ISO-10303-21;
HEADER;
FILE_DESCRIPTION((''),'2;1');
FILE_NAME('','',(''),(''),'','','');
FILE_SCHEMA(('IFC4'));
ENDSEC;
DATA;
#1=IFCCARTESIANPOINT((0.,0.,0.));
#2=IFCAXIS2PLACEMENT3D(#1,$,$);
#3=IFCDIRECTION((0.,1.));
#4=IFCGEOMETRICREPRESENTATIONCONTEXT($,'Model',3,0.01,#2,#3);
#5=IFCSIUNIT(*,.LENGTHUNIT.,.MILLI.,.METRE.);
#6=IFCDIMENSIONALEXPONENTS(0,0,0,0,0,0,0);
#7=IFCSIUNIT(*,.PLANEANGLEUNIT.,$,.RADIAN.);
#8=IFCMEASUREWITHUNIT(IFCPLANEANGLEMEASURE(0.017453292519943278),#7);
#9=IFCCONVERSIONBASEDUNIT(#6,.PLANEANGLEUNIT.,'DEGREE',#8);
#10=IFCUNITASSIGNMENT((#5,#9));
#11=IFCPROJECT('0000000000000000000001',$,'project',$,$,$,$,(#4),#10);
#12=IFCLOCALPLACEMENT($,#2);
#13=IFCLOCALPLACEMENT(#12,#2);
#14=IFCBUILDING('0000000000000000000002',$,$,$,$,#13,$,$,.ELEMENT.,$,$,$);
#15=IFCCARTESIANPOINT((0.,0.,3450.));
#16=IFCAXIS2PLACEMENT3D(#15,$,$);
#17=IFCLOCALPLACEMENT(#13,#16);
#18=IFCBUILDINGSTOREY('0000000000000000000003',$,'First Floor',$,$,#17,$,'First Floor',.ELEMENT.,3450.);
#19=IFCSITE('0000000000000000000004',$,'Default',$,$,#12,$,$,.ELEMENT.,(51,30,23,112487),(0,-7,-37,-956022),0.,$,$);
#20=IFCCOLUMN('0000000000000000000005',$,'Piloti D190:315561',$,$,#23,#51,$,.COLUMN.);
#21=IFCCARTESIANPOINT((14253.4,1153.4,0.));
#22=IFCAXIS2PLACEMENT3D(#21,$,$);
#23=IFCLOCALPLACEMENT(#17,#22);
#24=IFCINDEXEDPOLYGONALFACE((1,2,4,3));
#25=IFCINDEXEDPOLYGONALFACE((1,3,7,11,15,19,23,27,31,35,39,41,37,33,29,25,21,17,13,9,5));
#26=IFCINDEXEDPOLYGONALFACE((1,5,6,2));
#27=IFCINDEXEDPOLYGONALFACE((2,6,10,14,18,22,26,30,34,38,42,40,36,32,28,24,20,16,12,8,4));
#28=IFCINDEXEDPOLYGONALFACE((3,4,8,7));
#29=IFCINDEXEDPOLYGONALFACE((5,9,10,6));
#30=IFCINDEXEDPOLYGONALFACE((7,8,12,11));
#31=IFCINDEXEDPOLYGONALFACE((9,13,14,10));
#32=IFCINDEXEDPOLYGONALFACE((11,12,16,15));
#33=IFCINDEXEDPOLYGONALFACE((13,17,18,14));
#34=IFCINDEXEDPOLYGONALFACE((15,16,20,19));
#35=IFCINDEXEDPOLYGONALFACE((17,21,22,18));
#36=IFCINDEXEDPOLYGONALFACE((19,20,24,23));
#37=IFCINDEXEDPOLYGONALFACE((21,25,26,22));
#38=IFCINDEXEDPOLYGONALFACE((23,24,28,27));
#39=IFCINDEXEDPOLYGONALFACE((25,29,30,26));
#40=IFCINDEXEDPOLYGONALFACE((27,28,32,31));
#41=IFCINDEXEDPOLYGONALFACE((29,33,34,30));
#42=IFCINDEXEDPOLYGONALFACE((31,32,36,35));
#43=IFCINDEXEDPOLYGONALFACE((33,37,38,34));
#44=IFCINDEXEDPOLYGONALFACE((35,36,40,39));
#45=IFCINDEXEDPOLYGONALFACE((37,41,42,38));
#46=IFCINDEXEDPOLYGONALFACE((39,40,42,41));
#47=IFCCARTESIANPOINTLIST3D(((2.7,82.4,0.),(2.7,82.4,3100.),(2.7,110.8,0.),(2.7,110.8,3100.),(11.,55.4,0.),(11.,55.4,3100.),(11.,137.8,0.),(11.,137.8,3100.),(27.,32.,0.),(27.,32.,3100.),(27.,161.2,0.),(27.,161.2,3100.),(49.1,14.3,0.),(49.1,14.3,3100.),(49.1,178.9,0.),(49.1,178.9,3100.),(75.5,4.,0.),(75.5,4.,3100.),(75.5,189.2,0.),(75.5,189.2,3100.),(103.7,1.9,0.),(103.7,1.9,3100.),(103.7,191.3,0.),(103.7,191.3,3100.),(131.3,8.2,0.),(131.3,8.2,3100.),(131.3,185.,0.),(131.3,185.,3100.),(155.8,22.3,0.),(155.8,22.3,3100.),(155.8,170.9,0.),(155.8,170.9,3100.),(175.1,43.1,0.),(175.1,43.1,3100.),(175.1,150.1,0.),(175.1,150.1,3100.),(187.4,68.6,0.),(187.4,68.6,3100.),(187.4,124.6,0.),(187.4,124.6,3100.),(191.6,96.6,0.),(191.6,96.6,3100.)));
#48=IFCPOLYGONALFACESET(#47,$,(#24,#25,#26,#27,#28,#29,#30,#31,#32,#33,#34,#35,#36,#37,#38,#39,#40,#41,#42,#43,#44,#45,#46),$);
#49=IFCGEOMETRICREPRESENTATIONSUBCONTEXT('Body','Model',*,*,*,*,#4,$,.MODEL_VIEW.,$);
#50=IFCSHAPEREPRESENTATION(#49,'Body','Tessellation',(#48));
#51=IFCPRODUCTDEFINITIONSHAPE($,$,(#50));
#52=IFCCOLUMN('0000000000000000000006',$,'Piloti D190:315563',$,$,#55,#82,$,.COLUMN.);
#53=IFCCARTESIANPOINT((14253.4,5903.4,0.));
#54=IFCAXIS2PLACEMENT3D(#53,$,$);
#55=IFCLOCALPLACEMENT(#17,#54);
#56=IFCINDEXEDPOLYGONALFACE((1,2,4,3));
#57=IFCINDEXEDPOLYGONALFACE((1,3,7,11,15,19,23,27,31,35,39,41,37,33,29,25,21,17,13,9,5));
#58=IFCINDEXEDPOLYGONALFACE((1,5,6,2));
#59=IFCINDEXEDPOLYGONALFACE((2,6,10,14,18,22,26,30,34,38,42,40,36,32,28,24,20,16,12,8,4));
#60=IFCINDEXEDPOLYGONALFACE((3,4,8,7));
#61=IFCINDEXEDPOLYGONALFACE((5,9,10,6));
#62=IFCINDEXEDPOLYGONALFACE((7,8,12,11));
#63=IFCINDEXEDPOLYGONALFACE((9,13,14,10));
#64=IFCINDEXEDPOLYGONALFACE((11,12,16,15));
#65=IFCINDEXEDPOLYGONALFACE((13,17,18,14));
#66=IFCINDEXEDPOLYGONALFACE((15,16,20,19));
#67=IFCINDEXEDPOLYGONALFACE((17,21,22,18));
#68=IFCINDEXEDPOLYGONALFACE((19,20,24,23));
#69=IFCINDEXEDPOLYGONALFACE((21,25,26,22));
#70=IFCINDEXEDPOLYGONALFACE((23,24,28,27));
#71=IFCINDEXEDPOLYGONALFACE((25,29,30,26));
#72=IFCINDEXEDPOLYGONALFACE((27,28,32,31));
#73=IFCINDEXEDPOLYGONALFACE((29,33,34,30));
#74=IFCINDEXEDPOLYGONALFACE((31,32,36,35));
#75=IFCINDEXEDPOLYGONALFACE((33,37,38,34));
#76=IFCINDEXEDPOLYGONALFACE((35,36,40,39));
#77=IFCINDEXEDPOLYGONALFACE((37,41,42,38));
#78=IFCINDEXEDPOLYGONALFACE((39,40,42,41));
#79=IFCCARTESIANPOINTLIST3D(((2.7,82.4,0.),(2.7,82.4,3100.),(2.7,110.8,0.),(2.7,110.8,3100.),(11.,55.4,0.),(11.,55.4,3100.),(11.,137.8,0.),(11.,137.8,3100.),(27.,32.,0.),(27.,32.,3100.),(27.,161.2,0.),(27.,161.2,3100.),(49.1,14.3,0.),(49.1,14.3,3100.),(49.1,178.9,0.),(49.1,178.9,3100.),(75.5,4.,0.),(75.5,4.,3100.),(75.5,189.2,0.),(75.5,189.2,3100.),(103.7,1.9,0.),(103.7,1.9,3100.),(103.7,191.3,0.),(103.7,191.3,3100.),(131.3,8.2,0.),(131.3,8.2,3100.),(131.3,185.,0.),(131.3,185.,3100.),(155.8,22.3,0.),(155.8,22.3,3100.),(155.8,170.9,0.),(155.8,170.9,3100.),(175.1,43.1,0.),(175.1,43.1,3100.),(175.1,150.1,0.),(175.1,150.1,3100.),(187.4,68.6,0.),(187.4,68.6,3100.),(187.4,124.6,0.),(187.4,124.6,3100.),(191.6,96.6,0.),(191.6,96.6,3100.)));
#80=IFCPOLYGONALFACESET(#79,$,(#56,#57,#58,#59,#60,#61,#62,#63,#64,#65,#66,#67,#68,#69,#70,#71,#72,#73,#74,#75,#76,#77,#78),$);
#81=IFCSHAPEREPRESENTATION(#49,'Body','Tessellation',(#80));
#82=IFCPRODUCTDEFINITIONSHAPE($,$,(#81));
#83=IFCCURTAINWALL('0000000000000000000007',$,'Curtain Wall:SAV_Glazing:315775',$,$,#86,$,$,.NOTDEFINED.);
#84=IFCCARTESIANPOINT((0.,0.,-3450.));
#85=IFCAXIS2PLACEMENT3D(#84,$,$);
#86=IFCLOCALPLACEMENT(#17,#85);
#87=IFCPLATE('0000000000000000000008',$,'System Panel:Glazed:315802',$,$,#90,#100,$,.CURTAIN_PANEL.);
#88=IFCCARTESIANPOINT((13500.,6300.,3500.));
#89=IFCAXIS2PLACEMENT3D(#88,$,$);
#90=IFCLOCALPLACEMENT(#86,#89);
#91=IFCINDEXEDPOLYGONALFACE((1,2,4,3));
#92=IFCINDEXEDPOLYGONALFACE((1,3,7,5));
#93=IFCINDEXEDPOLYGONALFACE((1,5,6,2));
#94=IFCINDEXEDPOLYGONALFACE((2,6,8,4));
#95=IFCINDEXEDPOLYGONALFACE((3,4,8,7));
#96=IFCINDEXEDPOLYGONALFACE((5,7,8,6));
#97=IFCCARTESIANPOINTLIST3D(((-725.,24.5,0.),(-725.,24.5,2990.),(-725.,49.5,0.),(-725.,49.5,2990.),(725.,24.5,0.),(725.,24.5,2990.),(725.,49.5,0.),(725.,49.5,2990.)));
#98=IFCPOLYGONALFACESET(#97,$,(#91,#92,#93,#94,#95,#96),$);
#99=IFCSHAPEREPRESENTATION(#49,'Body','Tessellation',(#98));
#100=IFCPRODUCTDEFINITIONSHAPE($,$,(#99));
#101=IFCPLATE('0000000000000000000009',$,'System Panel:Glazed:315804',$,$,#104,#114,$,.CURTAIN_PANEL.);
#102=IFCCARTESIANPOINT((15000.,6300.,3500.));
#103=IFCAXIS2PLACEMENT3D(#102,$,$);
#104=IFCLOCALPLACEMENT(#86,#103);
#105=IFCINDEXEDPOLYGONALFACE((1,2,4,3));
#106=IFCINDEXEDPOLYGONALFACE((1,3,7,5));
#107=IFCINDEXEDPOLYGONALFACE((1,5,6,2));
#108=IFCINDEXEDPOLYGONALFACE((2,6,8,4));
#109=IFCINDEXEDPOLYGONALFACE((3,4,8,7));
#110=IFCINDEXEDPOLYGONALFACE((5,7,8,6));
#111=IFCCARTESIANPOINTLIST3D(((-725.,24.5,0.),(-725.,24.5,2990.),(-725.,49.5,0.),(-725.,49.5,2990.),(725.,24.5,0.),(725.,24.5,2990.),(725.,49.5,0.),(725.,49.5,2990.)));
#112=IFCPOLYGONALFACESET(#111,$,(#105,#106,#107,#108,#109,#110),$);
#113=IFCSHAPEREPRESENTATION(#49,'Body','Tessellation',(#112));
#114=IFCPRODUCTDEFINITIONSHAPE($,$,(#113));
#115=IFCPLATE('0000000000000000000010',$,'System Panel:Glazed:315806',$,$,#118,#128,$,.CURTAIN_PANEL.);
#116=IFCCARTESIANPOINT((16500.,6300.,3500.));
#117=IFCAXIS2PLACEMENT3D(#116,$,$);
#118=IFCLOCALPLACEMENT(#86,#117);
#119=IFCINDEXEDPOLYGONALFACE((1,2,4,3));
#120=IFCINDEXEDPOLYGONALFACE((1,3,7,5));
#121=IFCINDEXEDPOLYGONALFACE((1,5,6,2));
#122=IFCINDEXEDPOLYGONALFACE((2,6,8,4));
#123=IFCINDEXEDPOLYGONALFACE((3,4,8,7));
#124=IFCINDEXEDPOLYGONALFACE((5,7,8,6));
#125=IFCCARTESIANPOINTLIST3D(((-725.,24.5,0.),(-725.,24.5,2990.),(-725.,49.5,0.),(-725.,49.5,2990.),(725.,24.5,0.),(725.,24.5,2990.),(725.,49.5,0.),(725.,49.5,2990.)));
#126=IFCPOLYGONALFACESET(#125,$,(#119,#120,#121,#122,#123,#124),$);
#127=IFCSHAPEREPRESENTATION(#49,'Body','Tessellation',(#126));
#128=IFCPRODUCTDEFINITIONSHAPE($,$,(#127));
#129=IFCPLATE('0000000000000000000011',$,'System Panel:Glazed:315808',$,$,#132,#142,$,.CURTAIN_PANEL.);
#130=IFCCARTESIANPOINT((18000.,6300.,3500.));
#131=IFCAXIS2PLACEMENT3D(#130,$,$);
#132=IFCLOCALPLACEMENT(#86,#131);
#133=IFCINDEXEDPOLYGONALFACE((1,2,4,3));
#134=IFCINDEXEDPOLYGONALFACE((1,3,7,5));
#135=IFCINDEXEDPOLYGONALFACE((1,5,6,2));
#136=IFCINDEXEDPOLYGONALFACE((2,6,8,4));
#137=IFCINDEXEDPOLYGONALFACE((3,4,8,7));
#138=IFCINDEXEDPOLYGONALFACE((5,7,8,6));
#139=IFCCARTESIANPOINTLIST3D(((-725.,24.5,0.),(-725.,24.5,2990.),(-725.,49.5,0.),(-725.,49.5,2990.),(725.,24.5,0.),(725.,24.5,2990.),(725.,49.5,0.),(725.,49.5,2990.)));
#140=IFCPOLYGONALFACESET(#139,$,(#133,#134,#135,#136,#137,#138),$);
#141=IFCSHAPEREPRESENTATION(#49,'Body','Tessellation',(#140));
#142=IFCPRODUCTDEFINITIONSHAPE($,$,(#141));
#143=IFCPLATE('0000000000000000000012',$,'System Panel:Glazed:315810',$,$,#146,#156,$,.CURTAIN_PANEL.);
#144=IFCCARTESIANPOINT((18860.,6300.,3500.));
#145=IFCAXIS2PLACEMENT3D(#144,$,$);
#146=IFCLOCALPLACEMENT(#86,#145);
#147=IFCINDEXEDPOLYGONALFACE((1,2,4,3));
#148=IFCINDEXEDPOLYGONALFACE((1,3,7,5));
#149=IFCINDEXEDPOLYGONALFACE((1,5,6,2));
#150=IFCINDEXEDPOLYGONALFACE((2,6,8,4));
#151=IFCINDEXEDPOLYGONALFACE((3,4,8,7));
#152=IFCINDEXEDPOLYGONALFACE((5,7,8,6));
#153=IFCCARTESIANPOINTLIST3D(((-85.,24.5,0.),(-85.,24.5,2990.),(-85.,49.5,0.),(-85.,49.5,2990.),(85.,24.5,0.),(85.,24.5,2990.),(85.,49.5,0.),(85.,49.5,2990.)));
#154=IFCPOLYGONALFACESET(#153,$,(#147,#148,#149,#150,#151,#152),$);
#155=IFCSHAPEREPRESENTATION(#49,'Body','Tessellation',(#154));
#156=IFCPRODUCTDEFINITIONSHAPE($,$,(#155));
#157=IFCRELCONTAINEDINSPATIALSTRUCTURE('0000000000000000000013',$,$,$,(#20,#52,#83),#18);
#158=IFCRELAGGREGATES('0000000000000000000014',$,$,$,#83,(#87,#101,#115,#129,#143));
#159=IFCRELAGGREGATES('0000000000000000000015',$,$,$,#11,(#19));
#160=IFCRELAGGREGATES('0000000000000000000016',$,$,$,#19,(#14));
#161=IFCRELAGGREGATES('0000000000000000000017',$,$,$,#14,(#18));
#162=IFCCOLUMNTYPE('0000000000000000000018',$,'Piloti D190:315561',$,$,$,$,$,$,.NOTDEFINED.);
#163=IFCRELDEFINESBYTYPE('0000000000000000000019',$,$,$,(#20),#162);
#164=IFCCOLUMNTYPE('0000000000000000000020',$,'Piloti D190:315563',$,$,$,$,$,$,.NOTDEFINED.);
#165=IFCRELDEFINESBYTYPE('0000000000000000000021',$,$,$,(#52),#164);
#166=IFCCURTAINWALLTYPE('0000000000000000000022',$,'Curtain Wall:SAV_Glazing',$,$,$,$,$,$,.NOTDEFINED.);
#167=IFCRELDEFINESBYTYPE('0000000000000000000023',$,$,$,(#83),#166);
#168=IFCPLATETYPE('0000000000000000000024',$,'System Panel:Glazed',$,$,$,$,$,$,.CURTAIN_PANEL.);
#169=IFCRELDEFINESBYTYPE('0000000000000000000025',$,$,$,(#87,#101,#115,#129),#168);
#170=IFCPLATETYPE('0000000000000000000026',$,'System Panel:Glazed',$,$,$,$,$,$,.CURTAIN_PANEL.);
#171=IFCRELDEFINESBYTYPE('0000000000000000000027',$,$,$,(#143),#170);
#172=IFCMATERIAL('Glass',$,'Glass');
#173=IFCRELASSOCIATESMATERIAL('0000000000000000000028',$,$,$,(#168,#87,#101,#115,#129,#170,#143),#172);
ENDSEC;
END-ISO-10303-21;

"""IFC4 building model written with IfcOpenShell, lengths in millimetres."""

from ifc_helpers import new_model, entity, si_unit, converted_unit, direction, frame, origin, origin_2d_with_axis, place, context, subcontext, project, spatial, rectangle, circle, extrude, source, transform, mapped, material, type_object, type_shapes, element, aggregate, save


model = new_model("IFC4")

# Units and contexts
model_context = context("Model", 3, precision=0.01, world=origin(), true_north=direction((0.0, 1.0)))
body_context = subcontext(model_context, "Body", "Model", "MODEL_VIEW")
ifc_project = project(units=[si_unit("LENGTHUNIT", "METRE", prefix="MILLI"), converted_unit("PLANEANGLEUNIT", "DEGREE", entity("IfcPlaneAngleMeasure", 0.017453292519943278), si_unit("PLANEANGLEUNIT", "RADIAN"), dimensions=[0, 0, 0, 0, 0, 0, 0])], contexts=[model_context])

# Site, building, storey
site_placement = place(None, origin())
site = spatial("IfcSite", under=ifc_project, at=site_placement, Name="Default", CompositionType="ELEMENT", RefLatitude=(51, 30, 23, 112487), RefLongitude=(0, -7, -37, -956022), RefElevation=0.0)
building_placement = place(site_placement, origin())
building = spatial("IfcBuilding", under=site, at=building_placement, CompositionType="ELEMENT")
storey_placement = place(building_placement, frame((0.0, 0.0, 3450.0)))
storey = spatial("IfcBuildingStorey", under=building, at=storey_placement, Name="First Floor", LongName="First Floor", CompositionType="ELEMENT", Elevation=3450.0)

# Columns
column_type_1 = type_object("IfcColumnType", Name="Piloti D190:315561", PredefinedType="NOTDEFINED")
column_1_placement = place(storey_placement, frame((14253.4, 1153.4, 0.0)))
element("IfcColumn", 1, at=column_1_placement, inside=storey, type_object=column_type_1, Name="Piloti D190:315561", PredefinedType="COLUMN", context=body_context, shape_type="SweptSolid", body=[
    extrude(circle(Radius=95.0, at=origin_2d_with_axis()), frame((96.6, 96.6, 0.0)), (0.0, 0.0, 1.0), 3100.0),
])
column_type_2 = type_object("IfcColumnType", Name="Piloti D190:315563", PredefinedType="NOTDEFINED")
column_2_placement = place(storey_placement, frame((14253.4, 5903.4, 0.0)))
element("IfcColumn", 2, at=column_2_placement, inside=storey, type_object=column_type_2, Name="Piloti D190:315563", PredefinedType="COLUMN", context=body_context, shape_type="SweptSolid", body=[
    extrude(circle(Radius=95.0, at=origin_2d_with_axis()), frame((96.6, 96.6, 0.0)), (0.0, 0.0, 1.0), 3100.0),
])

# Curtain wall, plates
curtain_wall_type = type_object("IfcCurtainWallType", Name="Curtain Wall:SAV_Glazing", PredefinedType="NOTDEFINED")
curtain_wall_placement = place(storey_placement, frame((0.0, 0.0, -3450.0)))
curtain_wall = element("IfcCurtainWall", 3, at=curtain_wall_placement, inside=storey, type_object=curtain_wall_type, Name="Curtain Wall:SAV_Glazing:315775", PredefinedType="NOTDEFINED")
ifc_material_1 = material(Name="Glass", Category="Glass")
plate_type_1 = type_object("IfcPlateType", Name="System Panel:Glazed", PredefinedType="CURTAIN_PANEL", material=ifc_material_1)
shared_shape_1 = source(origin(), body_context, "Body", "SweptSolid", [
    extrude(rectangle(XDim=25.0, YDim=1450.0, at=origin_2d_with_axis()), frame((0.0, 37.0, 0.0), z_axis=(0.0, 0.0, 1.0), x_axis=(0.0, 1.0, 0.0)), (0.0, 0.0, 1.0), 2990.0),
])
type_shapes(plate_type_1, [shared_shape_1])
plate_1_placement = place(curtain_wall_placement, frame((13500.0, 6300.0, 3500.0)))
plate_1 = element("IfcPlate", 4, at=plate_1_placement, type_object=plate_type_1, material=ifc_material_1, Name="System Panel:Glazed:315802", PredefinedType="CURTAIN_PANEL", context=body_context, shape_type="MappedRepresentation", body=[
    mapped(shared_shape_1, transform((0.0, 0.0, 0.0), scale=1.0)),
])
plate_2_placement = place(curtain_wall_placement, frame((15000.0, 6300.0, 3500.0)))
plate_2 = element("IfcPlate", 5, at=plate_2_placement, type_object=plate_type_1, material=ifc_material_1, Name="System Panel:Glazed:315804", PredefinedType="CURTAIN_PANEL", context=body_context, shape_type="MappedRepresentation", body=[
    mapped(shared_shape_1, transform((0.0, 0.0, 0.0), scale=1.0)),
])
plate_3_placement = place(curtain_wall_placement, frame((16500.0, 6300.0, 3500.0)))
plate_3 = element("IfcPlate", 6, at=plate_3_placement, type_object=plate_type_1, material=ifc_material_1, Name="System Panel:Glazed:315806", PredefinedType="CURTAIN_PANEL", context=body_context, shape_type="MappedRepresentation", body=[
    mapped(shared_shape_1, transform((0.0, 0.0, 0.0), scale=1.0)),
])
plate_4_placement = place(curtain_wall_placement, frame((18000.0, 6300.0, 3500.0)))
plate_4 = element("IfcPlate", 7, at=plate_4_placement, type_object=plate_type_1, material=ifc_material_1, Name="System Panel:Glazed:315808", PredefinedType="CURTAIN_PANEL", context=body_context, shape_type="MappedRepresentation", body=[
    mapped(shared_shape_1, transform((0.0, 0.0, 0.0), scale=1.0)),
])
plate_type_2 = type_object("IfcPlateType", Name="System Panel:Glazed", PredefinedType="CURTAIN_PANEL", material=ifc_material_1)
shared_shape_2 = source(origin(), body_context, "Body", "SweptSolid", [
    extrude(rectangle(XDim=25.0, YDim=170.0, at=origin_2d_with_axis()), frame((0.0, 37.0, 0.0), z_axis=(0.0, 0.0, 1.0), x_axis=(0.0, 1.0, 0.0)), (0.0, 0.0, 1.0), 2990.0),
])
type_shapes(plate_type_2, [shared_shape_2])
plate_5_placement = place(curtain_wall_placement, frame((18860.0, 6300.0, 3500.0)))
plate_5 = element("IfcPlate", 8, at=plate_5_placement, type_object=plate_type_2, material=ifc_material_1, Name="System Panel:Glazed:315810", PredefinedType="CURTAIN_PANEL", context=body_context, shape_type="MappedRepresentation", body=[
    mapped(shared_shape_2, transform((0.0, 0.0, 0.0), scale=1.0)),
])
aggregate(curtain_wall, [plate_1, plate_2, plate_3, plate_4, plate_5])

save(model, "model.ifc")
